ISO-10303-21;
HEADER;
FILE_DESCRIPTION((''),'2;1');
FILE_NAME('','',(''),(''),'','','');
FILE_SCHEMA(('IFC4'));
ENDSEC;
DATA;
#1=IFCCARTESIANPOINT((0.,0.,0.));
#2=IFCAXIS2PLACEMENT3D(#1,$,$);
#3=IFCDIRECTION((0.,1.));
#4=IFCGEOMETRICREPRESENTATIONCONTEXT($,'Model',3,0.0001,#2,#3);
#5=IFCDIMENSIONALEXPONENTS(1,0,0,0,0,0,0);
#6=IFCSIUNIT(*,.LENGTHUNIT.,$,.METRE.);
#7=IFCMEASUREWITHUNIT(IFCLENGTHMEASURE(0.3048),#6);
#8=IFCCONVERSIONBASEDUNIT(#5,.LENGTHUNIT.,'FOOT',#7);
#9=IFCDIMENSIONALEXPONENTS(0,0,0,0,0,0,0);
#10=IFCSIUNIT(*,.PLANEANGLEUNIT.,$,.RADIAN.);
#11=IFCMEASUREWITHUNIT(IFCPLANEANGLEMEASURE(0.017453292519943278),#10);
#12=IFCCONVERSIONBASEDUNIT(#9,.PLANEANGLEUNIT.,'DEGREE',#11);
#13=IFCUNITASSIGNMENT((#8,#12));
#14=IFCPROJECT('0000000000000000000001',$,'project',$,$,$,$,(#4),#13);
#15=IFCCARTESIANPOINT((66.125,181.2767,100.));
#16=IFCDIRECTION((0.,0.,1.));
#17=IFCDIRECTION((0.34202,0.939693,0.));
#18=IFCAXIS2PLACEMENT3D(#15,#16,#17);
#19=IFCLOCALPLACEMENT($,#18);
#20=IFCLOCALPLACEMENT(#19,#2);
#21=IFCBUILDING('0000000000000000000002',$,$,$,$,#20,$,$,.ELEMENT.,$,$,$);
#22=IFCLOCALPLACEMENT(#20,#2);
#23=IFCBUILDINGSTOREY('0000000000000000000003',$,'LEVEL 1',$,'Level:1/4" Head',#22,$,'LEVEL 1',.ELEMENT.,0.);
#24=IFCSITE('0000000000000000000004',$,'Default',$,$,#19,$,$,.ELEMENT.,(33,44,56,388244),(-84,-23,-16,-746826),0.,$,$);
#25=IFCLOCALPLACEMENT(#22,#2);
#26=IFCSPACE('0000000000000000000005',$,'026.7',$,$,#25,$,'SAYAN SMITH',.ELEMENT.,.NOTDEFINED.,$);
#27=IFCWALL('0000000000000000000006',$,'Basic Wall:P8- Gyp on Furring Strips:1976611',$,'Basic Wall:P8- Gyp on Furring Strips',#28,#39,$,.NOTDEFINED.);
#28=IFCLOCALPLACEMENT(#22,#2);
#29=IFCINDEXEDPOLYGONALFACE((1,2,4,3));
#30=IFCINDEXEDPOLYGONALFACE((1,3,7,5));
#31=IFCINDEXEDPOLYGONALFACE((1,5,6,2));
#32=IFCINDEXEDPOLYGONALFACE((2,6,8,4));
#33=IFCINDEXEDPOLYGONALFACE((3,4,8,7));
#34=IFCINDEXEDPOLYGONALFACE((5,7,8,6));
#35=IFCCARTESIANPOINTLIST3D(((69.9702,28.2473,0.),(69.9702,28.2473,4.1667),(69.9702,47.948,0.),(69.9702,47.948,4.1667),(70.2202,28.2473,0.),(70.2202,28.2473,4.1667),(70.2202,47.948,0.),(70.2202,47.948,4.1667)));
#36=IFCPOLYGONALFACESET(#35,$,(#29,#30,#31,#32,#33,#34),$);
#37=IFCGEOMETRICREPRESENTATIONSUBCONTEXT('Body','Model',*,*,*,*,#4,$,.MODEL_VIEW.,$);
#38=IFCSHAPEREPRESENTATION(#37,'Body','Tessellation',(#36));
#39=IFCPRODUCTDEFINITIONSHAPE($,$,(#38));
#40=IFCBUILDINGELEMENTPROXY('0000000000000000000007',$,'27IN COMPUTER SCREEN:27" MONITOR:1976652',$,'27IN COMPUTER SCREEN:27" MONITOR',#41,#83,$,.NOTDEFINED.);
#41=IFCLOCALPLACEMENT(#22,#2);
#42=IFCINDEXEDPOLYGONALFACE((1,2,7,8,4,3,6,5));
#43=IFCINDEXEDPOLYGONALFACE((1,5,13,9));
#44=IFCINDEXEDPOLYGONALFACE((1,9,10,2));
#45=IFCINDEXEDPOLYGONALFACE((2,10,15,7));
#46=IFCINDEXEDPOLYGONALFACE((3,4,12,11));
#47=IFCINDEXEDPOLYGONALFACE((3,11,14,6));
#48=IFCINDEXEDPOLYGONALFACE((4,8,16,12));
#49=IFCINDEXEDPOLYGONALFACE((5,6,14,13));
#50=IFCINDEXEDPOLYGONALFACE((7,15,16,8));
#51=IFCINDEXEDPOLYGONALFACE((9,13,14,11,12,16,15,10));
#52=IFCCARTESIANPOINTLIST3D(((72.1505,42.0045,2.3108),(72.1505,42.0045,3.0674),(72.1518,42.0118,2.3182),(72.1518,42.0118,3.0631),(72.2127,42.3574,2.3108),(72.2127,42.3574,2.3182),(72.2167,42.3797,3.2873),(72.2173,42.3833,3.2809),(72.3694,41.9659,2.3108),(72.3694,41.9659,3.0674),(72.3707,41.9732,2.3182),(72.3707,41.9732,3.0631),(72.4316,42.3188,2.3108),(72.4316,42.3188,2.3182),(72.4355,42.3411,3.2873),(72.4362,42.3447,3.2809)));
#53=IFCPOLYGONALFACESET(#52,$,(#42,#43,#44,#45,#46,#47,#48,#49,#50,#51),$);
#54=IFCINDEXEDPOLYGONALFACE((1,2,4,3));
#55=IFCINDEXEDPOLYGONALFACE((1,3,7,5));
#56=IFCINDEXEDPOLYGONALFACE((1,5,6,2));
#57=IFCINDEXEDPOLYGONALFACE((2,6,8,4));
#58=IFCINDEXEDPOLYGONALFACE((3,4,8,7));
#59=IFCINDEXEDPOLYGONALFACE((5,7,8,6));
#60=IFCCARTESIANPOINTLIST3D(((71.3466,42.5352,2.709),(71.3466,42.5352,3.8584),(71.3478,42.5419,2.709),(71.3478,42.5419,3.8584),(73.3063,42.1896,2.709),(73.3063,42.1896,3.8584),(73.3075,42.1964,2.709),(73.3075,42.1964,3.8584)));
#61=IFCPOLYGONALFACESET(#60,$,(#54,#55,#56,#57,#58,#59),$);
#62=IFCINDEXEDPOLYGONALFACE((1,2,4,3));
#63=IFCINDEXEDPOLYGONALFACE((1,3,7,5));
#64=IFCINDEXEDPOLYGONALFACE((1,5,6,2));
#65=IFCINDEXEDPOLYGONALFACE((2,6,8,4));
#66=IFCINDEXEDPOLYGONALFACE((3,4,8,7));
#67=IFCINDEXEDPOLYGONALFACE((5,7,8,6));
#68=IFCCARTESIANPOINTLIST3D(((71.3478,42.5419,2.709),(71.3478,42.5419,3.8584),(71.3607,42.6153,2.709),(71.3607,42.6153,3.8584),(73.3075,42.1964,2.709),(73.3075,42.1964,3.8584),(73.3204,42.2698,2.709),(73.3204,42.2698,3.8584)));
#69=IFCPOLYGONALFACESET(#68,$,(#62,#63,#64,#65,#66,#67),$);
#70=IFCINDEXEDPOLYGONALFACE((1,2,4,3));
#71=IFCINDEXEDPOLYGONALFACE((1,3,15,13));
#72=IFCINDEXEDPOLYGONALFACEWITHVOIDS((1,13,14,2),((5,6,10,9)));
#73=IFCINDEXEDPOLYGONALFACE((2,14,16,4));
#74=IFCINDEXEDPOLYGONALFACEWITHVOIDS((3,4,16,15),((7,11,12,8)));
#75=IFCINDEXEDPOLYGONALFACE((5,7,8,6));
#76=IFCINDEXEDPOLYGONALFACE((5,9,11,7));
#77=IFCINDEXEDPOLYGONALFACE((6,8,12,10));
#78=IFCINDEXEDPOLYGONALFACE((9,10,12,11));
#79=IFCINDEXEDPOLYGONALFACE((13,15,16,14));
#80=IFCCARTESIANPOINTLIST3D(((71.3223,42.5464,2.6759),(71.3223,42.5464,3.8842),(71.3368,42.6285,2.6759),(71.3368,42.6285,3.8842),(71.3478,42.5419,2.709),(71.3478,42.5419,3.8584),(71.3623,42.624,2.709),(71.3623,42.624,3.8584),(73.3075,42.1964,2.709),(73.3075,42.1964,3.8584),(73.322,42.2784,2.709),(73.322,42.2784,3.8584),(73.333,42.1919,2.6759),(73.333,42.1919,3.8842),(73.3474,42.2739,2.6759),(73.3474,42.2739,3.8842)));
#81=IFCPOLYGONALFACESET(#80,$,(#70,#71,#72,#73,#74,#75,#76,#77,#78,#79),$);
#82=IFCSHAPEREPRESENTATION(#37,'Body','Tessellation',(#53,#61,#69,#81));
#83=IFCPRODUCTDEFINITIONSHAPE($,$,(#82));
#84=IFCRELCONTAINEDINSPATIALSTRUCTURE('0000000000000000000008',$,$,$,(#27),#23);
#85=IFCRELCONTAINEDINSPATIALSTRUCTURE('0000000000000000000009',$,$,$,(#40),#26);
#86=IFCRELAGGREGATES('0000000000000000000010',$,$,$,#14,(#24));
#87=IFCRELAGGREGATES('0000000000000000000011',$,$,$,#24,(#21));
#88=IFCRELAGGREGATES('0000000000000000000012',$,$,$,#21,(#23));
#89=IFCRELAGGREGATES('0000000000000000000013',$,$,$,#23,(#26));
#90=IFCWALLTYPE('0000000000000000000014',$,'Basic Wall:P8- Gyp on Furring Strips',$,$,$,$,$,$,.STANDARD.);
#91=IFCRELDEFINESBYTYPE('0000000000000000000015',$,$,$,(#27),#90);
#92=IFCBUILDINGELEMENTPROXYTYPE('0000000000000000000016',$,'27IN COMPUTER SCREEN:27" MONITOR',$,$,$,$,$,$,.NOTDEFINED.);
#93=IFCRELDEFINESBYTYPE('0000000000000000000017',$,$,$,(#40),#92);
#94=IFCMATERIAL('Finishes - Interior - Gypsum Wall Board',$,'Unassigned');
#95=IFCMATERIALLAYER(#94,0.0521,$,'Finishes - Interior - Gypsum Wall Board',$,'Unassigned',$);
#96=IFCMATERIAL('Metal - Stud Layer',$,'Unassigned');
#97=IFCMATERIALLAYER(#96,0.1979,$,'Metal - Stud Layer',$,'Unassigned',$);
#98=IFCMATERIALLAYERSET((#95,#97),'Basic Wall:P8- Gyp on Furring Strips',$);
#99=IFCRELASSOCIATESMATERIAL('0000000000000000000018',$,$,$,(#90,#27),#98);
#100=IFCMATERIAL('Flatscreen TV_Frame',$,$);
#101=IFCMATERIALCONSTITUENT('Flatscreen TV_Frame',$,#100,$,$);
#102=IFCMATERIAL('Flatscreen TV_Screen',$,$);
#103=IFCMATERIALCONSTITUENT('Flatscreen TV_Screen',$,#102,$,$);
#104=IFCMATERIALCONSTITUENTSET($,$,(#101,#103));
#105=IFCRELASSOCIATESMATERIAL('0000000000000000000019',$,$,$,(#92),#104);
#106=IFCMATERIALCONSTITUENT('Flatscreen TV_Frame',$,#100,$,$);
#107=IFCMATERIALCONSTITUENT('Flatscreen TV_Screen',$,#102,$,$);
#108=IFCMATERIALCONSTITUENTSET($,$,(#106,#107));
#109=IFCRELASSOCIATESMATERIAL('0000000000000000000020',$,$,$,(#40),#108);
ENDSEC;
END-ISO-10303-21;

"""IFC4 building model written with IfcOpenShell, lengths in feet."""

from ifc_helpers import new_model, entity, si_unit, converted_unit, direction, frame, frame_2d, origin, origin_2d_with_axis, place, context, subcontext, project, spatial, polyline, rectangle, outline, extrude, source, transform, mapped, material, layer, layer_set, layer_usage, constituent, constituent_set, type_object, type_shapes, element, save


model = new_model("IFC4")

# Units and contexts
model_context = context("Model", 3, precision=0.0001, world=origin(), true_north=direction((0.0, 1.0)))
body_context = subcontext(model_context, "Body", "Model", "MODEL_VIEW")
ifc_project = project(units=[converted_unit("LENGTHUNIT", "FOOT", entity("IfcLengthMeasure", 0.3048), si_unit("LENGTHUNIT", "METRE"), dimensions=[1, 0, 0, 0, 0, 0, 0]), converted_unit("PLANEANGLEUNIT", "DEGREE", entity("IfcPlaneAngleMeasure", 0.017453292519943278), si_unit("PLANEANGLEUNIT", "RADIAN"), dimensions=[0, 0, 0, 0, 0, 0, 0])], contexts=[model_context])

# Site, building, storey
site_placement = place(None, frame((66.125, 181.2767, 100.0), z_axis=(0.0, 0.0, 1.0), x_axis=(0.34202, 0.939693, 0.0)))
site = spatial("IfcSite", under=ifc_project, at=site_placement, Name="Default", CompositionType="ELEMENT", RefLatitude=(33, 44, 56, 388244), RefLongitude=(-84, -23, -16, -746826), RefElevation=0.0)
building_placement = place(site_placement, origin())
building = spatial("IfcBuilding", under=site, at=building_placement, CompositionType="ELEMENT")
storey_placement = place(building_placement, origin())
storey = spatial("IfcBuildingStorey", under=building, at=storey_placement, Name="LEVEL 1", ObjectType="Level:1/4\" Head", LongName="LEVEL 1", CompositionType="ELEMENT", Elevation=0.0)

# Shared definitions
ifc_material_1 = material(Name="Metal - Stud Layer", Category="Unassigned")

# Wall
ifc_material_2 = material(Name="Finishes - Interior - Gypsum Wall Board", Category="Unassigned")
ifc_layer_1 = layer(ifc_material_2, 0.0521, Name="Finishes - Interior - Gypsum Wall Board", Category="Unassigned")
ifc_layer_2 = layer(ifc_material_1, 0.1979, Name="Metal - Stud Layer", Category="Unassigned")
ifc_layer_set_1 = layer_set([ifc_layer_1, ifc_layer_2], Name="Basic Wall:P8- Gyp on Furring Strips")
ifc_layer_usage_1 = layer_usage(ifc_layer_set_1, "AXIS2", "NEGATIVE", 0.125)
wall_type_1 = type_object("IfcWallType", Name="Basic Wall:P8- Gyp on Furring Strips", PredefinedType="STANDARD", material=ifc_layer_set_1)
wall_1_placement = place(storey_placement, frame((70.0952, 47.948, 0.0), z_axis=(0.0, 0.0, 1.0), x_axis=(0.0, -1.0, 0.0)))
element("IfcWall", 1, at=wall_1_placement, inside=storey, type_object=wall_type_1, material=ifc_layer_usage_1, Name="Basic Wall:P8- Gyp on Furring Strips:1976611", ObjectType="Basic Wall:P8- Gyp on Furring Strips", PredefinedType="NOTDEFINED", context=body_context, shape_type="SweptSolid", body=[
    extrude(rectangle(XDim=19.7008, YDim=0.25, at=frame_2d((9.8504, 0.0), x_axis=(-1.0, 0.0))), origin(), (0.0, 0.0, 1.0), 4.1667),
])

# Shared definitions
space_1_placement = place(storey_placement, origin())
space_1 = spatial("IfcSpace", under=storey, at=space_1_placement, Name="026.7", LongName="SAYAN SMITH", CompositionType="ELEMENT", PredefinedType="NOTDEFINED")

# Building element proxy
ifc_material_3 = material(Name="Flatscreen TV_Frame")
ifc_constituent_1 = constituent(ifc_material_3, Name="Flatscreen TV_Frame")
ifc_material_4 = material(Name="Flatscreen TV_Screen")
ifc_constituent_2 = constituent(ifc_material_4, Name="Flatscreen TV_Screen")
ifc_constituent_set_1 = constituent_set(constituents=[ifc_constituent_1, ifc_constituent_2])
ifc_constituent_3 = constituent(ifc_material_3, Name="Flatscreen TV_Frame")
ifc_constituent_4 = constituent(ifc_material_4, Name="Flatscreen TV_Screen")
ifc_constituent_set_2 = constituent_set(constituents=[ifc_constituent_3, ifc_constituent_4])
building_element_proxy_type_1 = type_object("IfcBuildingElementProxyType", Name="27IN COMPUTER SCREEN:27\" MONITOR", PredefinedType="NOTDEFINED", material=ifc_constituent_set_2)
shared_shape_1 = source(origin(), body_context, "Body", "SweptSolid", [
    extrude(outline(polyline([(-0.4392, -0.3657), (-0.4392, -0.3731), (0.0007, -0.3731), (0.379, 0.2821), (0.0686, 0.4613), (0.0649, 0.4548), (0.3688, 0.2794), (-0.0036, -0.3657), (-0.4392, -0.3657)])), frame((-0.1111, -0.0264, 0.0687), z_axis=(-1.0, 0.0, 0.0), x_axis=(0.0, 0.866025, -0.5)), (0.0, 0.0, -1.0), 0.2222),
    extrude(rectangle(XDim=0.0068, YDim=1.9899, at=origin_2d_with_axis()), frame((0.0, -0.2257, 0.0331), z_axis=(0.0, 0.0, 1.0), x_axis=(0.0, 1.0, 0.0)), (0.0, 0.0, 1.0), 1.1493),
    extrude(rectangle(XDim=0.0746, YDim=1.9899, at=frame_2d((0.0, 0.0), x_axis=(1.0, 0.0))), frame((0.0, -0.2664, 0.0331), z_axis=(0.0, 0.0, 1.0), x_axis=(0.0, 1.0, 0.0)), (0.0, 0.0, 1.0), 1.1493),
    extrude(outline(polyline([(-0.6042, -1.0208), (0.6042, -1.0208), (0.6042, 1.0208), (-0.6042, 1.0208), (-0.6042, -1.0208)]), holes=[polyline([(-0.5783, -0.995), (-0.5783, 0.995), (0.571, 0.995), (0.571, -0.995), (-0.5783, -0.995)])]), frame((0.0, -0.3125, 0.6042), z_axis=(0.0, 1.0, 0.0), x_axis=(0.0, 0.0, -1.0)), (0.0, 0.0, 1.0), 0.0833),
])
type_shapes(building_element_proxy_type_1, [shared_shape_1])
proxy_1_placement = place(space_1_placement, frame((72.2878, 42.1435, 2.6759), z_axis=(0.0, 0.0, 1.0), x_axis=(-0.984808, 0.173648, 0.0)))
element("IfcBuildingElementProxy", 2, at=proxy_1_placement, inside=space_1, type_object=building_element_proxy_type_1, material=ifc_constituent_set_1, Name="27IN COMPUTER SCREEN:27\" MONITOR:1976652", ObjectType="27IN COMPUTER SCREEN:27\" MONITOR", PredefinedType="NOTDEFINED", context=body_context, shape_type="MappedRepresentation", body=[
    mapped(shared_shape_1, transform((0.0, 0.0, 0.0), scale=1.0)),
])

save(model, "model.ifc")
